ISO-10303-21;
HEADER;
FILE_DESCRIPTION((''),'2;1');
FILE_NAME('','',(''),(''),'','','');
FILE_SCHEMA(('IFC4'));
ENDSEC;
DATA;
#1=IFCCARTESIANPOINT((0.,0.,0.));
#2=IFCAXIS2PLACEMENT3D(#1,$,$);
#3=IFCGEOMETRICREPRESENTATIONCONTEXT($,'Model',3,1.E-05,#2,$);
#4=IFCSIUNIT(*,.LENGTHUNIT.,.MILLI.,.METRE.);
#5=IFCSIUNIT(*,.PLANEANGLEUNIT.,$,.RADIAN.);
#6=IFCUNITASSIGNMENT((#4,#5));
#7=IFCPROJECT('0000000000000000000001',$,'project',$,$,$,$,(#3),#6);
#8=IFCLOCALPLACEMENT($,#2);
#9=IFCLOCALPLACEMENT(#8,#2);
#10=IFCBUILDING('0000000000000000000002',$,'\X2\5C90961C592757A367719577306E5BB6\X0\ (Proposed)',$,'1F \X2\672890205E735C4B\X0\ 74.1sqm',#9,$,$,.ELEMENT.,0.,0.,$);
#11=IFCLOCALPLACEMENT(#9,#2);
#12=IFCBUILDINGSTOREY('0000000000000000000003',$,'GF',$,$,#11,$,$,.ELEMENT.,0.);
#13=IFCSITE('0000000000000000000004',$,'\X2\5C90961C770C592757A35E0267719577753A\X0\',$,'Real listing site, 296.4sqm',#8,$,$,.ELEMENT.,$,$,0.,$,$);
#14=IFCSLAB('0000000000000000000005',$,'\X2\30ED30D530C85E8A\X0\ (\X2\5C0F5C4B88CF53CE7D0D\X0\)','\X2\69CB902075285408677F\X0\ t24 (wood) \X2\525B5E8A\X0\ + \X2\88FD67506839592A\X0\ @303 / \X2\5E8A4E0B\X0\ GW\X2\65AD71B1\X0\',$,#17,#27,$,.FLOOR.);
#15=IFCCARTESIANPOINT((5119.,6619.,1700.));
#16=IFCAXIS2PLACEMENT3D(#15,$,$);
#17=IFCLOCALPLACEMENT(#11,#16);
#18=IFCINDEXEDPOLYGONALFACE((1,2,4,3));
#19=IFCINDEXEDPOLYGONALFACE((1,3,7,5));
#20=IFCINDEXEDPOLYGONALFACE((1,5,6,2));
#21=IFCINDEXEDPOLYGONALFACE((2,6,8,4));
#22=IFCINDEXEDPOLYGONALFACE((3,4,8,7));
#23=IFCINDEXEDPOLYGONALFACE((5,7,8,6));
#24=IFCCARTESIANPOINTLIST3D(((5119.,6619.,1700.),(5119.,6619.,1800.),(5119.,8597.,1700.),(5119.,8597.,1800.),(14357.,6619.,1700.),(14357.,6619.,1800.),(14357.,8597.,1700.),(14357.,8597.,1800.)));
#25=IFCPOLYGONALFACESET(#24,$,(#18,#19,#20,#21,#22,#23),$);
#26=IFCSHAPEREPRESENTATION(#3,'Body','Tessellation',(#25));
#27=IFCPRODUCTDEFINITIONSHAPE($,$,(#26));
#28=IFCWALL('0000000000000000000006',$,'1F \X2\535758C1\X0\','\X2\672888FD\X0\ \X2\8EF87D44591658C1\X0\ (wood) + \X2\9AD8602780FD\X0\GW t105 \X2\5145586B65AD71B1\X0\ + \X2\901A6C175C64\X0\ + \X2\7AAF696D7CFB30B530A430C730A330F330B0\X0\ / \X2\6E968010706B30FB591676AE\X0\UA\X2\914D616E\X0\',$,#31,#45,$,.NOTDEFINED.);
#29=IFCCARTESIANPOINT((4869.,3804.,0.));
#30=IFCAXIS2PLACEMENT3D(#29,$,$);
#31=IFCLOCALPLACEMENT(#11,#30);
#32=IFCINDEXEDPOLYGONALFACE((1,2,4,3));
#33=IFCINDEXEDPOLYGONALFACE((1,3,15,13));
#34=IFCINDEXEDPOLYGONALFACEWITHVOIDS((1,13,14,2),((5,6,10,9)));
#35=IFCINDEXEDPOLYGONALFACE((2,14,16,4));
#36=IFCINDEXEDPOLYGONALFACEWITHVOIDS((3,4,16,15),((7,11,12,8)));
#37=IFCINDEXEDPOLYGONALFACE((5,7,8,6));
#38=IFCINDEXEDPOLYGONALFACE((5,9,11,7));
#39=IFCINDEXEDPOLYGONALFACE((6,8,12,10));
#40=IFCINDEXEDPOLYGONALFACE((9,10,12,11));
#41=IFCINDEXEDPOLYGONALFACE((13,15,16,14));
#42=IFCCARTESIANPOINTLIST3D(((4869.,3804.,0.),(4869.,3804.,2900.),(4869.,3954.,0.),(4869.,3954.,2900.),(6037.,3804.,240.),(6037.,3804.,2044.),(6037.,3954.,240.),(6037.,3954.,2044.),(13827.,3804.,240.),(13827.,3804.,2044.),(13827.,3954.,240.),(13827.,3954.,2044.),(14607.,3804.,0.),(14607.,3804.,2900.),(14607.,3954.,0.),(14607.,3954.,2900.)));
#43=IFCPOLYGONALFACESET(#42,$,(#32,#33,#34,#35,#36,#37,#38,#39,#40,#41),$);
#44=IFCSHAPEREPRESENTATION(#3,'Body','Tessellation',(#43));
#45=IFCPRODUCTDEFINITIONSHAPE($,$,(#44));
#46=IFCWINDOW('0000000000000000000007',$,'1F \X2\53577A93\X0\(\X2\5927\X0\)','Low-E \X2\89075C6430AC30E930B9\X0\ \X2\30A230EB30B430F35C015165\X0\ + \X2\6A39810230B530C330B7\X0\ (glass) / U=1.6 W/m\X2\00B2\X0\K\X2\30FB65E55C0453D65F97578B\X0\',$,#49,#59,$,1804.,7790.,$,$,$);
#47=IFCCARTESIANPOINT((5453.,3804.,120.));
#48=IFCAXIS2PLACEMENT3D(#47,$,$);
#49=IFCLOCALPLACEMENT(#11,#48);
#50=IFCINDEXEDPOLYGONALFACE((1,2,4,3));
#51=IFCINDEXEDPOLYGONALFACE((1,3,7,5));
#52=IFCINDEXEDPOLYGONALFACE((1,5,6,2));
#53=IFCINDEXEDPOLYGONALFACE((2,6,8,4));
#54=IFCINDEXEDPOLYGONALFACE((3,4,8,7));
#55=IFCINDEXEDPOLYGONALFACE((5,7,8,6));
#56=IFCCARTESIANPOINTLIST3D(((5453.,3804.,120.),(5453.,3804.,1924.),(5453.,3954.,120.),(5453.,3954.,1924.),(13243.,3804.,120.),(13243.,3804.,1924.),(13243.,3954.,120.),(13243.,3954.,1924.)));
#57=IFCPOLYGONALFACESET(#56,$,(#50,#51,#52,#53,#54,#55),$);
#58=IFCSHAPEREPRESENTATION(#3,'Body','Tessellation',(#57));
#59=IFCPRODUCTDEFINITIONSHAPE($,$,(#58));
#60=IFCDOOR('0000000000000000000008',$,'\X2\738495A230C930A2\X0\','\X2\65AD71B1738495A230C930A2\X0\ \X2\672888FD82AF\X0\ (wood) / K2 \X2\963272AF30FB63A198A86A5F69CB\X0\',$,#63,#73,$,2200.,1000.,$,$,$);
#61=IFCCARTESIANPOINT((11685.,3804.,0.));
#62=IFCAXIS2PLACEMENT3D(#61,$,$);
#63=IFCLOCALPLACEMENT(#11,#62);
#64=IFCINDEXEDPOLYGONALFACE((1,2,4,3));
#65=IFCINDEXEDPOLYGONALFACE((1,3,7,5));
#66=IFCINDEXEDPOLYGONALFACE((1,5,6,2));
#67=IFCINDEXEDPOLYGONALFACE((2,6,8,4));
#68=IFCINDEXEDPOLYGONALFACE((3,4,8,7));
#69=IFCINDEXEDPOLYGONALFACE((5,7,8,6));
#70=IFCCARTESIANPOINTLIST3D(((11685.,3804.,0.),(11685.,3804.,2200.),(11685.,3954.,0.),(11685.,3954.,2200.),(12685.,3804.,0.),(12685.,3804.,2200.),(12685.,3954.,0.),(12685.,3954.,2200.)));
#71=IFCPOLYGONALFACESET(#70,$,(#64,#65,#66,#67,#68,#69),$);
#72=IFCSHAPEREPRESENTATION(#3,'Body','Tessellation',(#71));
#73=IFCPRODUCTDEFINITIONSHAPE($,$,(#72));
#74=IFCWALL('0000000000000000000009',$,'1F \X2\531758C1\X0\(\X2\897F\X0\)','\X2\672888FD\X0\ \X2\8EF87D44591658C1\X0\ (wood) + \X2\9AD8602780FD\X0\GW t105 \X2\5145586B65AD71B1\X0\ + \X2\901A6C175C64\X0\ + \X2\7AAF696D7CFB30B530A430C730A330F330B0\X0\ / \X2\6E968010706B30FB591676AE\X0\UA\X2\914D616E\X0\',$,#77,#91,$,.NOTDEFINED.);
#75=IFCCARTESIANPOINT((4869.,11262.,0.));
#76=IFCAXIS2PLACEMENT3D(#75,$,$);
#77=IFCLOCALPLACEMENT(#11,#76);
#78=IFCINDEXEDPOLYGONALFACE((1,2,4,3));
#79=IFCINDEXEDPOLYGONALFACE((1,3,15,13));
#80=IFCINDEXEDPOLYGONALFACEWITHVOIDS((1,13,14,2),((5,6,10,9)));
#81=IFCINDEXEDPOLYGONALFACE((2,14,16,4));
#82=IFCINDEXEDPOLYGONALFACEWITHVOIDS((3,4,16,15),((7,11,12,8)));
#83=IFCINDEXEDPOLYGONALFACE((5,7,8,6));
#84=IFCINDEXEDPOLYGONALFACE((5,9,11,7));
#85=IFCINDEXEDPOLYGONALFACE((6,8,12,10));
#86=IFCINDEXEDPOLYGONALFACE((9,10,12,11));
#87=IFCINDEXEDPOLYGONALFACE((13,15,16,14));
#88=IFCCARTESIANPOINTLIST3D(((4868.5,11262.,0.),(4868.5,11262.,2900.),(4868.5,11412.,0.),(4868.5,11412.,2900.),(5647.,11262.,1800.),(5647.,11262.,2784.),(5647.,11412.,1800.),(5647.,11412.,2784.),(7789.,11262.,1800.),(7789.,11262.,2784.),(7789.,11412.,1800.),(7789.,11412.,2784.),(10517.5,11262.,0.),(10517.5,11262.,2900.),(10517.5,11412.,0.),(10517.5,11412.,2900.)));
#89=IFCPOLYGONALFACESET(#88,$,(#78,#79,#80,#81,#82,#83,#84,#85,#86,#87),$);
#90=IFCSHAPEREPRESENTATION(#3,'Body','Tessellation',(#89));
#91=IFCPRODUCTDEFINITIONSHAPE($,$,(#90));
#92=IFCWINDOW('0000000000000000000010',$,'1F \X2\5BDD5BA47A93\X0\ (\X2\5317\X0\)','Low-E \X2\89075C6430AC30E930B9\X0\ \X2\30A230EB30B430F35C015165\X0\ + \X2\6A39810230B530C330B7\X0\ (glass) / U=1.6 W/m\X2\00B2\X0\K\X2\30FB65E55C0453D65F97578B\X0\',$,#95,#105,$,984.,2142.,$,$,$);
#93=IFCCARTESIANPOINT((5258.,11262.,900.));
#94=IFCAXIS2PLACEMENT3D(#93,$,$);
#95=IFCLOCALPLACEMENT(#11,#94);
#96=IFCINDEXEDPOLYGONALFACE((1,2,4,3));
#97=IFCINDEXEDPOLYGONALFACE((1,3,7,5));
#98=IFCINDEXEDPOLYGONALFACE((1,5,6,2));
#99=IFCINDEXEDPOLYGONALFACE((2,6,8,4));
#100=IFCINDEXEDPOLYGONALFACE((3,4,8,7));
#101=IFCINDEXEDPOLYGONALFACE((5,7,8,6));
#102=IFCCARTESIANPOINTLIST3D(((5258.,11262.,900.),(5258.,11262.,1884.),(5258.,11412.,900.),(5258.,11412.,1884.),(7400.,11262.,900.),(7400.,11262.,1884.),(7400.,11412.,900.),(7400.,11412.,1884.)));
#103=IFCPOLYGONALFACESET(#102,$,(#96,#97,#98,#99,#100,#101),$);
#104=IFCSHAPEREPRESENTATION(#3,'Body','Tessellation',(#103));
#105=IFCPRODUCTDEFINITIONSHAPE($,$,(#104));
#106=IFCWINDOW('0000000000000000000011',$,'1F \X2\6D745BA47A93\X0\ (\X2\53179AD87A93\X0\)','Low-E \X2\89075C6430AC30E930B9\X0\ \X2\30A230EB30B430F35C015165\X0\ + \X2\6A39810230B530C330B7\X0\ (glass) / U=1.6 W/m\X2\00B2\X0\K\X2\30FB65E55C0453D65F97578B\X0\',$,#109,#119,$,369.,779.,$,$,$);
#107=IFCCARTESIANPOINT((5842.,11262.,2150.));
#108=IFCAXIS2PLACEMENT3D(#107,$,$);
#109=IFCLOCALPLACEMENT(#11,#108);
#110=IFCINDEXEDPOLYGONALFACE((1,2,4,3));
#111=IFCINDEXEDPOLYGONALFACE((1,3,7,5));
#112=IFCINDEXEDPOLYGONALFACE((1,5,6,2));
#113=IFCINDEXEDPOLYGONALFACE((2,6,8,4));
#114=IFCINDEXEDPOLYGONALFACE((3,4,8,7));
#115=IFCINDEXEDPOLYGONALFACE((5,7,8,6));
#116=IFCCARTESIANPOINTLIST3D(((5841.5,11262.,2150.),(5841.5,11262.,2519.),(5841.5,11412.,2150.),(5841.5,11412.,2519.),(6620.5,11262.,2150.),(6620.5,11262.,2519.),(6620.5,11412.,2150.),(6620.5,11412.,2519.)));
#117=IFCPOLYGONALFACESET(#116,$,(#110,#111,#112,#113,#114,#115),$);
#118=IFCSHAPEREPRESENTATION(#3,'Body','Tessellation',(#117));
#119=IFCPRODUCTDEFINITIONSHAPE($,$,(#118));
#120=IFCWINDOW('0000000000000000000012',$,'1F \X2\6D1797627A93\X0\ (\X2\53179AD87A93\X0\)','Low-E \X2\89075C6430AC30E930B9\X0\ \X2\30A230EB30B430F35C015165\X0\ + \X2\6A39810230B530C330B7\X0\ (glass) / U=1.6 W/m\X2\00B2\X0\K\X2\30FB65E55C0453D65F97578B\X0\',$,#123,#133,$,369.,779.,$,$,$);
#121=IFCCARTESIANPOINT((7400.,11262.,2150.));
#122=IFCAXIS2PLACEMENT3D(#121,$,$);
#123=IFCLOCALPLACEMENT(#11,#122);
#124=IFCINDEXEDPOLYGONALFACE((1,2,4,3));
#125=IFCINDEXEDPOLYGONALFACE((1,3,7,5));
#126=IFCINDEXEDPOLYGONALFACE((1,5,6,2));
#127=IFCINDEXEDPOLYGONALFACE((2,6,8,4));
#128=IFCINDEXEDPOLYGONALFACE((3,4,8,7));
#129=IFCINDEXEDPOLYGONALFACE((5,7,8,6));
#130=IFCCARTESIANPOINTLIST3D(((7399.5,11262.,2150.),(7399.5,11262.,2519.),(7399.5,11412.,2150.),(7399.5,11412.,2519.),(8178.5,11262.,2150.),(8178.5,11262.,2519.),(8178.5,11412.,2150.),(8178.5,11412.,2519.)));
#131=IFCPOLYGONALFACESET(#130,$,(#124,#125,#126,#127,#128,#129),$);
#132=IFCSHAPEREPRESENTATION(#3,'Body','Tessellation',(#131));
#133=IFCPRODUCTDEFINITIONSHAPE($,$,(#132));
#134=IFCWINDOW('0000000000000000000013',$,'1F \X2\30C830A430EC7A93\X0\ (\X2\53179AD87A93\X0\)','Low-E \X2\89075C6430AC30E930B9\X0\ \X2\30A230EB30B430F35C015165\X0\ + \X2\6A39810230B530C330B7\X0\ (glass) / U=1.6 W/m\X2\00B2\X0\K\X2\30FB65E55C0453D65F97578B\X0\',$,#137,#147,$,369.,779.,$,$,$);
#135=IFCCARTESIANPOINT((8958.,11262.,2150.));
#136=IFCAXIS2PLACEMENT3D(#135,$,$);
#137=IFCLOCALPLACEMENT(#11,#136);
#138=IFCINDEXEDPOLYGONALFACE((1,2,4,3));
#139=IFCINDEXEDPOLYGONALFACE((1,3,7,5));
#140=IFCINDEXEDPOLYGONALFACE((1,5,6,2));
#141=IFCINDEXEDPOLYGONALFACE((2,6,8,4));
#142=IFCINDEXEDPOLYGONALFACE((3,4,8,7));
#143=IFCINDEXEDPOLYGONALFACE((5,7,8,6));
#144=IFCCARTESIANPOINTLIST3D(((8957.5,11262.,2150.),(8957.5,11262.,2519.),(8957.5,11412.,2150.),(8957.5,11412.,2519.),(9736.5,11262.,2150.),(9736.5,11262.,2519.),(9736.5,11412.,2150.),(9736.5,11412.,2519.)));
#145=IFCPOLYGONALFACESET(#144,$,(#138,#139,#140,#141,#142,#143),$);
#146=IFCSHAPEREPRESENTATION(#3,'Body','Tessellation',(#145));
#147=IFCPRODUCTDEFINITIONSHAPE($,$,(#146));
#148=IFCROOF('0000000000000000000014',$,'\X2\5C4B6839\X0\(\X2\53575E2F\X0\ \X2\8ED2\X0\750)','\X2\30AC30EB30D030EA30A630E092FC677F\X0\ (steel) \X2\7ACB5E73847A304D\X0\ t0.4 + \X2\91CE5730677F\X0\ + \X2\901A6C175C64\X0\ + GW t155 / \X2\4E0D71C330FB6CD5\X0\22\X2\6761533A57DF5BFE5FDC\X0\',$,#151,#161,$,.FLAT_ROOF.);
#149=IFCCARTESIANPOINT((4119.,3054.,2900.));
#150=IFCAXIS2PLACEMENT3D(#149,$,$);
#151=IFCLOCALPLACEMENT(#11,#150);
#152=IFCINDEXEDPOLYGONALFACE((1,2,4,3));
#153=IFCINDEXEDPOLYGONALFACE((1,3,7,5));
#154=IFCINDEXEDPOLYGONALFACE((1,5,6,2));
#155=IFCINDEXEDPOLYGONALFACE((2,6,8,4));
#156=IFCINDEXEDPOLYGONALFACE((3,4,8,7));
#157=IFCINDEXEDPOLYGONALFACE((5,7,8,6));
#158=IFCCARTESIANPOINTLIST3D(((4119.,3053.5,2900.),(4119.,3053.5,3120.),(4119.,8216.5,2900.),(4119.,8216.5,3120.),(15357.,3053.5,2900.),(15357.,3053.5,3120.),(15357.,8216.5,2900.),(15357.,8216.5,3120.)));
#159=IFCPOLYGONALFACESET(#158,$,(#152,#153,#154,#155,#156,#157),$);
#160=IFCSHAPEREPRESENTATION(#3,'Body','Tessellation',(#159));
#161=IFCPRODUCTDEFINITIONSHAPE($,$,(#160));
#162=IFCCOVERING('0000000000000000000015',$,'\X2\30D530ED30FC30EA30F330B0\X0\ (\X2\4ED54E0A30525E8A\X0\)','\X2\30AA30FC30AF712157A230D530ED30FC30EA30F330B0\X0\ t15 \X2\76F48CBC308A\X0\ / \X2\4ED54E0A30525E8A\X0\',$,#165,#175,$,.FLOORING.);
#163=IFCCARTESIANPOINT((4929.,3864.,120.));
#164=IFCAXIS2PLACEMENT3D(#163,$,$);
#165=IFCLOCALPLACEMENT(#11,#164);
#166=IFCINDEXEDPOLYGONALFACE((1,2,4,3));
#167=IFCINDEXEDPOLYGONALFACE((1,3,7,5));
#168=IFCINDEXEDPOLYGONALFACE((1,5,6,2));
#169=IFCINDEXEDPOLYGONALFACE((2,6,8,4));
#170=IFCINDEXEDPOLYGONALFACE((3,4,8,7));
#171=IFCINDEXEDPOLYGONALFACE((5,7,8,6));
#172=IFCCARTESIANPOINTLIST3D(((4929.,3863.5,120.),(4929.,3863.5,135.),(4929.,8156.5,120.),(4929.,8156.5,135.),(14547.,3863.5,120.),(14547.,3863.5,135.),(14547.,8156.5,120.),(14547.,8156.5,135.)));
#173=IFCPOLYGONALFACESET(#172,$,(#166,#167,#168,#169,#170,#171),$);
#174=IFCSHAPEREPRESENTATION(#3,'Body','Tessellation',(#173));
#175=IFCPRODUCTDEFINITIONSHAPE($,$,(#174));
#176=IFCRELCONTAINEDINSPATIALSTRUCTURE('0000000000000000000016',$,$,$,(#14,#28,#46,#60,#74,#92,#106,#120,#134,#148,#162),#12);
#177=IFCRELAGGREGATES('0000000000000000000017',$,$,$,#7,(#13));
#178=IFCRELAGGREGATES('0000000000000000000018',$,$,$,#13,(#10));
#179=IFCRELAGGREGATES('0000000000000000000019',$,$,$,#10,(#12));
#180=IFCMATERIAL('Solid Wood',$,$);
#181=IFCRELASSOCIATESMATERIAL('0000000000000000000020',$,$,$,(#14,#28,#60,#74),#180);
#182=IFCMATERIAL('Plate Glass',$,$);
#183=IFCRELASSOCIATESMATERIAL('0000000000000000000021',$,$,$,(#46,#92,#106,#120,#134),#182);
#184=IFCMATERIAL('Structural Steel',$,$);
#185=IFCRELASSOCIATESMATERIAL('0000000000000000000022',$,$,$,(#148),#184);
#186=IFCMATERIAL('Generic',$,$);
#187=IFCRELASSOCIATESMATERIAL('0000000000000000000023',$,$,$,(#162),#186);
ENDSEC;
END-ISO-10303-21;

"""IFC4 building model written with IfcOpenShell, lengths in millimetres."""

from ifc_helpers import new_model, si_unit, frame, frame_2d, origin, place, context, project, spatial, rectangle, extrude, material, element, fill, save


model = new_model("IFC4")

# Units and contexts
model_context = context("Model", 3, precision=1e-05, world=origin())
ifc_project = project(units=[si_unit("LENGTHUNIT", "METRE", prefix="MILLI"), si_unit("PLANEANGLEUNIT", "RADIAN")], contexts=[model_context])

# Site, building, storey
site_placement = place(None, origin())
site = spatial("IfcSite", under=ifc_project, at=site_placement, Name="岐阜県大垣市東長町", ObjectType="Real listing site, 296.4sqm", CompositionType="ELEMENT", RefElevation=0.0)
building_placement = place(site_placement, origin())
building = spatial("IfcBuilding", under=site, at=building_placement, Name="岐阜大垣東長の家 (Proposed)", ObjectType="1F 木造平屋 74.1sqm", CompositionType="ELEMENT", ElevationOfRefHeight=0.0, ElevationOfTerrain=0.0)
storey_placement = place(building_placement, origin())
storey = spatial("IfcBuildingStorey", under=building, at=storey_placement, Name="GF", CompositionType="ELEMENT", Elevation=0.0)

# Slab
ifc_material_1 = material(Name="Solid Wood")
slab_1_placement = place(storey_placement, frame((5119.0, 6619.0, 1700.0)))
element("IfcSlab", 1, at=slab_1_placement, inside=storey, material=ifc_material_1, Name="ロフト床 (小屋裏収納)", Description="構造用合板 t24 (wood) 剛床 + 製材根太 @303 / 床下 GW断熱", PredefinedType="FLOOR", context=model_context, shape_type="SweptSolid", body=[
    extrude(rectangle(XDim=9238.0, YDim=1978.0, at=frame_2d((4619.0, 989.0))), frame((5119.0, 6619.0, 1700.0)), (0.0, 0.0, 1.0), 100.0),
])

# Wall, openings, window, door
wall_1_placement = place(storey_placement, frame((4869.0, 3804.0, 0.0)))
wall_1 = element("IfcWall", 2, at=wall_1_placement, inside=storey, material=ifc_material_1, Name="1F 南壁", Description="木製 軸組外壁 (wood) + 高性能GW t105 充填断熱 + 通気層 + 窯業系サイディング / 準耐火・外皮UA配慮", PredefinedType="NOTDEFINED", context=model_context, shape_type="SweptSolid", body=[
    extrude(rectangle(XDim=9738.0, YDim=150.0, at=frame_2d((4869.0, 75.0))), frame((4869.0, 3804.0, 0.0)), (0.0, 0.0, 1.0), 2900.0),
])
opening_1_placement = place(storey_placement, frame((5453.0, 3804.0, 120.0)))
opening_1 = element("IfcOpeningElement", 3, at=opening_1_placement, cuts=wall_1, PredefinedType="NOTDEFINED", context=model_context, shape_type="SweptSolid", body=[
    extrude(rectangle(XDim=7790.0, YDim=150.0, at=frame_2d((3895.0, 75.0))), frame((5453.0, 3804.0, 120.0)), (0.0, 0.0, 1.0), 1804.0),
])
opening_2_placement = place(storey_placement, frame((11685.0, 3804.0, 0.0)))
opening_2 = element("IfcOpeningElement", 4, at=opening_2_placement, cuts=wall_1, PredefinedType="NOTDEFINED", context=model_context, shape_type="SweptSolid", body=[
    extrude(rectangle(XDim=1000.0, YDim=150.0, at=frame_2d((500.0, 75.0))), frame((11685.0, 3804.0, 0.0)), (0.0, 0.0, 1.0), 2200.0),
])
ifc_material_2 = material(Name="Plate Glass")
window_1_placement = place(storey_placement, frame((5453.0, 3804.0, 120.0)))
window_1 = element("IfcWindow", 5, at=window_1_placement, inside=storey, material=ifc_material_2, Name="1F 南窓(大)", Description="Low-E 複層ガラス アルゴン封入 + 樹脂サッシ (glass) / U=1.6 W/m²K・日射取得型", OverallHeight=1804.0, OverallWidth=7790.0, context=model_context, shape_type="SweptSolid", body=[
    extrude(rectangle(XDim=7790.0, YDim=150.0, at=frame_2d((3895.0, 75.0))), frame((5453.0, 3804.0, 120.0)), (0.0, 0.0, 1.0), 1804.0),
])
fill(opening_1, window_1)
door_placement = place(storey_placement, frame((11685.0, 3804.0, 0.0)))
door = element("IfcDoor", 6, at=door_placement, inside=storey, material=ifc_material_1, Name="玄関ドア", Description="断熱玄関ドア 木製芯 (wood) / K2 防犯・採風機構", OverallHeight=2200.0, OverallWidth=1000.0, context=model_context, shape_type="SweptSolid", body=[
    extrude(rectangle(XDim=1000.0, YDim=150.0, at=frame_2d((500.0, 75.0))), frame((11685.0, 3804.0, 0.0)), (0.0, 0.0, 1.0), 2200.0),
])
fill(opening_2, door)

# Wall, openings, windows
wall_2_placement = place(storey_placement, frame((4869.0, 11262.0, 0.0)))
wall_2 = element("IfcWall", 7, at=wall_2_placement, inside=storey, material=ifc_material_1, Name="1F 北壁(西)", Description="木製 軸組外壁 (wood) + 高性能GW t105 充填断熱 + 通気層 + 窯業系サイディング / 準耐火・外皮UA配慮", PredefinedType="NOTDEFINED", context=model_context, shape_type="SweptSolid", body=[
    extrude(rectangle(XDim=5649.0, YDim=150.0, at=frame_2d((2824.0, 75.0))), frame((4869.0, 11262.0, 0.0)), (0.0, 0.0, 1.0), 2900.0),
])
opening_3_placement = place(storey_placement, frame((5258.0, 11262.0, 900.0)))
opening_3 = element("IfcOpeningElement", 8, at=opening_3_placement, cuts=wall_2, PredefinedType="NOTDEFINED", context=model_context, shape_type="SweptSolid", body=[
    extrude(rectangle(XDim=2142.0, YDim=150.0, at=frame_2d((1071.0, 75.0))), frame((5258.0, 11262.0, 900.0)), (0.0, 0.0, 1.0), 984.0),
])
opening_4_placement = place(storey_placement, frame((5842.0, 11262.0, 2150.0)))
opening_4 = element("IfcOpeningElement", 9, at=opening_4_placement, cuts=wall_2, PredefinedType="NOTDEFINED", context=model_context, shape_type="SweptSolid", body=[
    extrude(rectangle(XDim=779.0, YDim=150.0, at=frame_2d((389.0, 75.0))), frame((5842.0, 11262.0, 2150.0)), (0.0, 0.0, 1.0), 369.0),
])
opening_5_placement = place(storey_placement, frame((7400.0, 11262.0, 2150.0)))
opening_5 = element("IfcOpeningElement", 10, at=opening_5_placement, cuts=wall_2, PredefinedType="NOTDEFINED", context=model_context, shape_type="SweptSolid", body=[
    extrude(rectangle(XDim=779.0, YDim=150.0, at=frame_2d((389.0, 75.0))), frame((7400.0, 11262.0, 2150.0)), (0.0, 0.0, 1.0), 369.0),
])
opening_6_placement = place(storey_placement, frame((8958.0, 11262.0, 2150.0)))
opening_6 = element("IfcOpeningElement", 11, at=opening_6_placement, cuts=wall_2, PredefinedType="NOTDEFINED", context=model_context, shape_type="SweptSolid", body=[
    extrude(rectangle(XDim=779.0, YDim=150.0, at=frame_2d((389.0, 75.0))), frame((8958.0, 11262.0, 2150.0)), (0.0, 0.0, 1.0), 369.0),
])
window_2_placement = place(storey_placement, frame((5258.0, 11262.0, 900.0)))
window_2 = element("IfcWindow", 12, at=window_2_placement, inside=storey, material=ifc_material_2, Name="1F 寝室窓 (北)", Description="Low-E 複層ガラス アルゴン封入 + 樹脂サッシ (glass) / U=1.6 W/m²K・日射取得型", OverallHeight=984.0, OverallWidth=2142.0, context=model_context, shape_type="SweptSolid", body=[
    extrude(rectangle(XDim=2142.0, YDim=150.0, at=frame_2d((1071.0, 75.0))), frame((5258.0, 11262.0, 900.0)), (0.0, 0.0, 1.0), 984.0),
])
fill(opening_3, window_2)
window_3_placement = place(storey_placement, frame((5842.0, 11262.0, 2150.0)))
window_3 = element("IfcWindow", 13, at=window_3_placement, inside=storey, material=ifc_material_2, Name="1F 浴室窓 (北高窓)", Description="Low-E 複層ガラス アルゴン封入 + 樹脂サッシ (glass) / U=1.6 W/m²K・日射取得型", OverallHeight=369.0, OverallWidth=779.0, context=model_context, shape_type="SweptSolid", body=[
    extrude(rectangle(XDim=779.0, YDim=150.0, at=frame_2d((389.0, 75.0))), frame((5842.0, 11262.0, 2150.0)), (0.0, 0.0, 1.0), 369.0),
])
fill(opening_4, window_3)
window_4_placement = place(storey_placement, frame((7400.0, 11262.0, 2150.0)))
window_4 = element("IfcWindow", 14, at=window_4_placement, inside=storey, material=ifc_material_2, Name="1F 洗面窓 (北高窓)", Description="Low-E 複層ガラス アルゴン封入 + 樹脂サッシ (glass) / U=1.6 W/m²K・日射取得型", OverallHeight=369.0, OverallWidth=779.0, context=model_context, shape_type="SweptSolid", body=[
    extrude(rectangle(XDim=779.0, YDim=150.0, at=frame_2d((389.0, 75.0))), frame((7400.0, 11262.0, 2150.0)), (0.0, 0.0, 1.0), 369.0),
])
fill(opening_5, window_4)
window_5_placement = place(storey_placement, frame((8958.0, 11262.0, 2150.0)))
window_5 = element("IfcWindow", 15, at=window_5_placement, inside=storey, material=ifc_material_2, Name="1F トイレ窓 (北高窓)", Description="Low-E 複層ガラス アルゴン封入 + 樹脂サッシ (glass) / U=1.6 W/m²K・日射取得型", OverallHeight=369.0, OverallWidth=779.0, context=model_context, shape_type="SweptSolid", body=[
    extrude(rectangle(XDim=779.0, YDim=150.0, at=frame_2d((389.0, 75.0))), frame((8958.0, 11262.0, 2150.0)), (0.0, 0.0, 1.0), 369.0),
])
fill(opening_6, window_5)

# Roof
ifc_material_3 = material(Name="Structural Steel")
roof_1_placement = place(storey_placement, frame((4119.0, 3054.0, 2900.0)))
element("IfcRoof", 16, at=roof_1_placement, inside=storey, material=ifc_material_3, Name="屋根(南帯 軒750)", Description="ガルバリウム鋼板 (steel) 立平葺き t0.4 + 野地板 + 通気層 + GW t155 / 不燃・法22条区域対応", PredefinedType="FLAT_ROOF", context=model_context, shape_type="SweptSolid", body=[
    extrude(rectangle(XDim=11238.0, YDim=5163.0, at=frame_2d((5619.0, 2581.0))), frame((4119.0, 3054.0, 2900.0)), (0.0, 0.0, 1.0), 220.0),
])

# Covering
ifc_material_4 = material(Name="Generic")
covering_1_placement = place(storey_placement, frame((4929.0, 3864.0, 120.0)))
element("IfcCovering", 17, at=covering_1_placement, inside=storey, material=ifc_material_4, Name="フローリング (仕上げ床)", Description="オーク無垢フローリング t15 直貼り / 仕上げ床", PredefinedType="FLOORING", context=model_context, shape_type="SweptSolid", body=[
    extrude(rectangle(XDim=9618.0, YDim=4293.0, at=frame_2d((4809.0, 2146.0))), frame((4929.0, 3864.0, 120.0)), (0.0, 0.0, 1.0), 15.0),
])

save(model, "model.ifc")
